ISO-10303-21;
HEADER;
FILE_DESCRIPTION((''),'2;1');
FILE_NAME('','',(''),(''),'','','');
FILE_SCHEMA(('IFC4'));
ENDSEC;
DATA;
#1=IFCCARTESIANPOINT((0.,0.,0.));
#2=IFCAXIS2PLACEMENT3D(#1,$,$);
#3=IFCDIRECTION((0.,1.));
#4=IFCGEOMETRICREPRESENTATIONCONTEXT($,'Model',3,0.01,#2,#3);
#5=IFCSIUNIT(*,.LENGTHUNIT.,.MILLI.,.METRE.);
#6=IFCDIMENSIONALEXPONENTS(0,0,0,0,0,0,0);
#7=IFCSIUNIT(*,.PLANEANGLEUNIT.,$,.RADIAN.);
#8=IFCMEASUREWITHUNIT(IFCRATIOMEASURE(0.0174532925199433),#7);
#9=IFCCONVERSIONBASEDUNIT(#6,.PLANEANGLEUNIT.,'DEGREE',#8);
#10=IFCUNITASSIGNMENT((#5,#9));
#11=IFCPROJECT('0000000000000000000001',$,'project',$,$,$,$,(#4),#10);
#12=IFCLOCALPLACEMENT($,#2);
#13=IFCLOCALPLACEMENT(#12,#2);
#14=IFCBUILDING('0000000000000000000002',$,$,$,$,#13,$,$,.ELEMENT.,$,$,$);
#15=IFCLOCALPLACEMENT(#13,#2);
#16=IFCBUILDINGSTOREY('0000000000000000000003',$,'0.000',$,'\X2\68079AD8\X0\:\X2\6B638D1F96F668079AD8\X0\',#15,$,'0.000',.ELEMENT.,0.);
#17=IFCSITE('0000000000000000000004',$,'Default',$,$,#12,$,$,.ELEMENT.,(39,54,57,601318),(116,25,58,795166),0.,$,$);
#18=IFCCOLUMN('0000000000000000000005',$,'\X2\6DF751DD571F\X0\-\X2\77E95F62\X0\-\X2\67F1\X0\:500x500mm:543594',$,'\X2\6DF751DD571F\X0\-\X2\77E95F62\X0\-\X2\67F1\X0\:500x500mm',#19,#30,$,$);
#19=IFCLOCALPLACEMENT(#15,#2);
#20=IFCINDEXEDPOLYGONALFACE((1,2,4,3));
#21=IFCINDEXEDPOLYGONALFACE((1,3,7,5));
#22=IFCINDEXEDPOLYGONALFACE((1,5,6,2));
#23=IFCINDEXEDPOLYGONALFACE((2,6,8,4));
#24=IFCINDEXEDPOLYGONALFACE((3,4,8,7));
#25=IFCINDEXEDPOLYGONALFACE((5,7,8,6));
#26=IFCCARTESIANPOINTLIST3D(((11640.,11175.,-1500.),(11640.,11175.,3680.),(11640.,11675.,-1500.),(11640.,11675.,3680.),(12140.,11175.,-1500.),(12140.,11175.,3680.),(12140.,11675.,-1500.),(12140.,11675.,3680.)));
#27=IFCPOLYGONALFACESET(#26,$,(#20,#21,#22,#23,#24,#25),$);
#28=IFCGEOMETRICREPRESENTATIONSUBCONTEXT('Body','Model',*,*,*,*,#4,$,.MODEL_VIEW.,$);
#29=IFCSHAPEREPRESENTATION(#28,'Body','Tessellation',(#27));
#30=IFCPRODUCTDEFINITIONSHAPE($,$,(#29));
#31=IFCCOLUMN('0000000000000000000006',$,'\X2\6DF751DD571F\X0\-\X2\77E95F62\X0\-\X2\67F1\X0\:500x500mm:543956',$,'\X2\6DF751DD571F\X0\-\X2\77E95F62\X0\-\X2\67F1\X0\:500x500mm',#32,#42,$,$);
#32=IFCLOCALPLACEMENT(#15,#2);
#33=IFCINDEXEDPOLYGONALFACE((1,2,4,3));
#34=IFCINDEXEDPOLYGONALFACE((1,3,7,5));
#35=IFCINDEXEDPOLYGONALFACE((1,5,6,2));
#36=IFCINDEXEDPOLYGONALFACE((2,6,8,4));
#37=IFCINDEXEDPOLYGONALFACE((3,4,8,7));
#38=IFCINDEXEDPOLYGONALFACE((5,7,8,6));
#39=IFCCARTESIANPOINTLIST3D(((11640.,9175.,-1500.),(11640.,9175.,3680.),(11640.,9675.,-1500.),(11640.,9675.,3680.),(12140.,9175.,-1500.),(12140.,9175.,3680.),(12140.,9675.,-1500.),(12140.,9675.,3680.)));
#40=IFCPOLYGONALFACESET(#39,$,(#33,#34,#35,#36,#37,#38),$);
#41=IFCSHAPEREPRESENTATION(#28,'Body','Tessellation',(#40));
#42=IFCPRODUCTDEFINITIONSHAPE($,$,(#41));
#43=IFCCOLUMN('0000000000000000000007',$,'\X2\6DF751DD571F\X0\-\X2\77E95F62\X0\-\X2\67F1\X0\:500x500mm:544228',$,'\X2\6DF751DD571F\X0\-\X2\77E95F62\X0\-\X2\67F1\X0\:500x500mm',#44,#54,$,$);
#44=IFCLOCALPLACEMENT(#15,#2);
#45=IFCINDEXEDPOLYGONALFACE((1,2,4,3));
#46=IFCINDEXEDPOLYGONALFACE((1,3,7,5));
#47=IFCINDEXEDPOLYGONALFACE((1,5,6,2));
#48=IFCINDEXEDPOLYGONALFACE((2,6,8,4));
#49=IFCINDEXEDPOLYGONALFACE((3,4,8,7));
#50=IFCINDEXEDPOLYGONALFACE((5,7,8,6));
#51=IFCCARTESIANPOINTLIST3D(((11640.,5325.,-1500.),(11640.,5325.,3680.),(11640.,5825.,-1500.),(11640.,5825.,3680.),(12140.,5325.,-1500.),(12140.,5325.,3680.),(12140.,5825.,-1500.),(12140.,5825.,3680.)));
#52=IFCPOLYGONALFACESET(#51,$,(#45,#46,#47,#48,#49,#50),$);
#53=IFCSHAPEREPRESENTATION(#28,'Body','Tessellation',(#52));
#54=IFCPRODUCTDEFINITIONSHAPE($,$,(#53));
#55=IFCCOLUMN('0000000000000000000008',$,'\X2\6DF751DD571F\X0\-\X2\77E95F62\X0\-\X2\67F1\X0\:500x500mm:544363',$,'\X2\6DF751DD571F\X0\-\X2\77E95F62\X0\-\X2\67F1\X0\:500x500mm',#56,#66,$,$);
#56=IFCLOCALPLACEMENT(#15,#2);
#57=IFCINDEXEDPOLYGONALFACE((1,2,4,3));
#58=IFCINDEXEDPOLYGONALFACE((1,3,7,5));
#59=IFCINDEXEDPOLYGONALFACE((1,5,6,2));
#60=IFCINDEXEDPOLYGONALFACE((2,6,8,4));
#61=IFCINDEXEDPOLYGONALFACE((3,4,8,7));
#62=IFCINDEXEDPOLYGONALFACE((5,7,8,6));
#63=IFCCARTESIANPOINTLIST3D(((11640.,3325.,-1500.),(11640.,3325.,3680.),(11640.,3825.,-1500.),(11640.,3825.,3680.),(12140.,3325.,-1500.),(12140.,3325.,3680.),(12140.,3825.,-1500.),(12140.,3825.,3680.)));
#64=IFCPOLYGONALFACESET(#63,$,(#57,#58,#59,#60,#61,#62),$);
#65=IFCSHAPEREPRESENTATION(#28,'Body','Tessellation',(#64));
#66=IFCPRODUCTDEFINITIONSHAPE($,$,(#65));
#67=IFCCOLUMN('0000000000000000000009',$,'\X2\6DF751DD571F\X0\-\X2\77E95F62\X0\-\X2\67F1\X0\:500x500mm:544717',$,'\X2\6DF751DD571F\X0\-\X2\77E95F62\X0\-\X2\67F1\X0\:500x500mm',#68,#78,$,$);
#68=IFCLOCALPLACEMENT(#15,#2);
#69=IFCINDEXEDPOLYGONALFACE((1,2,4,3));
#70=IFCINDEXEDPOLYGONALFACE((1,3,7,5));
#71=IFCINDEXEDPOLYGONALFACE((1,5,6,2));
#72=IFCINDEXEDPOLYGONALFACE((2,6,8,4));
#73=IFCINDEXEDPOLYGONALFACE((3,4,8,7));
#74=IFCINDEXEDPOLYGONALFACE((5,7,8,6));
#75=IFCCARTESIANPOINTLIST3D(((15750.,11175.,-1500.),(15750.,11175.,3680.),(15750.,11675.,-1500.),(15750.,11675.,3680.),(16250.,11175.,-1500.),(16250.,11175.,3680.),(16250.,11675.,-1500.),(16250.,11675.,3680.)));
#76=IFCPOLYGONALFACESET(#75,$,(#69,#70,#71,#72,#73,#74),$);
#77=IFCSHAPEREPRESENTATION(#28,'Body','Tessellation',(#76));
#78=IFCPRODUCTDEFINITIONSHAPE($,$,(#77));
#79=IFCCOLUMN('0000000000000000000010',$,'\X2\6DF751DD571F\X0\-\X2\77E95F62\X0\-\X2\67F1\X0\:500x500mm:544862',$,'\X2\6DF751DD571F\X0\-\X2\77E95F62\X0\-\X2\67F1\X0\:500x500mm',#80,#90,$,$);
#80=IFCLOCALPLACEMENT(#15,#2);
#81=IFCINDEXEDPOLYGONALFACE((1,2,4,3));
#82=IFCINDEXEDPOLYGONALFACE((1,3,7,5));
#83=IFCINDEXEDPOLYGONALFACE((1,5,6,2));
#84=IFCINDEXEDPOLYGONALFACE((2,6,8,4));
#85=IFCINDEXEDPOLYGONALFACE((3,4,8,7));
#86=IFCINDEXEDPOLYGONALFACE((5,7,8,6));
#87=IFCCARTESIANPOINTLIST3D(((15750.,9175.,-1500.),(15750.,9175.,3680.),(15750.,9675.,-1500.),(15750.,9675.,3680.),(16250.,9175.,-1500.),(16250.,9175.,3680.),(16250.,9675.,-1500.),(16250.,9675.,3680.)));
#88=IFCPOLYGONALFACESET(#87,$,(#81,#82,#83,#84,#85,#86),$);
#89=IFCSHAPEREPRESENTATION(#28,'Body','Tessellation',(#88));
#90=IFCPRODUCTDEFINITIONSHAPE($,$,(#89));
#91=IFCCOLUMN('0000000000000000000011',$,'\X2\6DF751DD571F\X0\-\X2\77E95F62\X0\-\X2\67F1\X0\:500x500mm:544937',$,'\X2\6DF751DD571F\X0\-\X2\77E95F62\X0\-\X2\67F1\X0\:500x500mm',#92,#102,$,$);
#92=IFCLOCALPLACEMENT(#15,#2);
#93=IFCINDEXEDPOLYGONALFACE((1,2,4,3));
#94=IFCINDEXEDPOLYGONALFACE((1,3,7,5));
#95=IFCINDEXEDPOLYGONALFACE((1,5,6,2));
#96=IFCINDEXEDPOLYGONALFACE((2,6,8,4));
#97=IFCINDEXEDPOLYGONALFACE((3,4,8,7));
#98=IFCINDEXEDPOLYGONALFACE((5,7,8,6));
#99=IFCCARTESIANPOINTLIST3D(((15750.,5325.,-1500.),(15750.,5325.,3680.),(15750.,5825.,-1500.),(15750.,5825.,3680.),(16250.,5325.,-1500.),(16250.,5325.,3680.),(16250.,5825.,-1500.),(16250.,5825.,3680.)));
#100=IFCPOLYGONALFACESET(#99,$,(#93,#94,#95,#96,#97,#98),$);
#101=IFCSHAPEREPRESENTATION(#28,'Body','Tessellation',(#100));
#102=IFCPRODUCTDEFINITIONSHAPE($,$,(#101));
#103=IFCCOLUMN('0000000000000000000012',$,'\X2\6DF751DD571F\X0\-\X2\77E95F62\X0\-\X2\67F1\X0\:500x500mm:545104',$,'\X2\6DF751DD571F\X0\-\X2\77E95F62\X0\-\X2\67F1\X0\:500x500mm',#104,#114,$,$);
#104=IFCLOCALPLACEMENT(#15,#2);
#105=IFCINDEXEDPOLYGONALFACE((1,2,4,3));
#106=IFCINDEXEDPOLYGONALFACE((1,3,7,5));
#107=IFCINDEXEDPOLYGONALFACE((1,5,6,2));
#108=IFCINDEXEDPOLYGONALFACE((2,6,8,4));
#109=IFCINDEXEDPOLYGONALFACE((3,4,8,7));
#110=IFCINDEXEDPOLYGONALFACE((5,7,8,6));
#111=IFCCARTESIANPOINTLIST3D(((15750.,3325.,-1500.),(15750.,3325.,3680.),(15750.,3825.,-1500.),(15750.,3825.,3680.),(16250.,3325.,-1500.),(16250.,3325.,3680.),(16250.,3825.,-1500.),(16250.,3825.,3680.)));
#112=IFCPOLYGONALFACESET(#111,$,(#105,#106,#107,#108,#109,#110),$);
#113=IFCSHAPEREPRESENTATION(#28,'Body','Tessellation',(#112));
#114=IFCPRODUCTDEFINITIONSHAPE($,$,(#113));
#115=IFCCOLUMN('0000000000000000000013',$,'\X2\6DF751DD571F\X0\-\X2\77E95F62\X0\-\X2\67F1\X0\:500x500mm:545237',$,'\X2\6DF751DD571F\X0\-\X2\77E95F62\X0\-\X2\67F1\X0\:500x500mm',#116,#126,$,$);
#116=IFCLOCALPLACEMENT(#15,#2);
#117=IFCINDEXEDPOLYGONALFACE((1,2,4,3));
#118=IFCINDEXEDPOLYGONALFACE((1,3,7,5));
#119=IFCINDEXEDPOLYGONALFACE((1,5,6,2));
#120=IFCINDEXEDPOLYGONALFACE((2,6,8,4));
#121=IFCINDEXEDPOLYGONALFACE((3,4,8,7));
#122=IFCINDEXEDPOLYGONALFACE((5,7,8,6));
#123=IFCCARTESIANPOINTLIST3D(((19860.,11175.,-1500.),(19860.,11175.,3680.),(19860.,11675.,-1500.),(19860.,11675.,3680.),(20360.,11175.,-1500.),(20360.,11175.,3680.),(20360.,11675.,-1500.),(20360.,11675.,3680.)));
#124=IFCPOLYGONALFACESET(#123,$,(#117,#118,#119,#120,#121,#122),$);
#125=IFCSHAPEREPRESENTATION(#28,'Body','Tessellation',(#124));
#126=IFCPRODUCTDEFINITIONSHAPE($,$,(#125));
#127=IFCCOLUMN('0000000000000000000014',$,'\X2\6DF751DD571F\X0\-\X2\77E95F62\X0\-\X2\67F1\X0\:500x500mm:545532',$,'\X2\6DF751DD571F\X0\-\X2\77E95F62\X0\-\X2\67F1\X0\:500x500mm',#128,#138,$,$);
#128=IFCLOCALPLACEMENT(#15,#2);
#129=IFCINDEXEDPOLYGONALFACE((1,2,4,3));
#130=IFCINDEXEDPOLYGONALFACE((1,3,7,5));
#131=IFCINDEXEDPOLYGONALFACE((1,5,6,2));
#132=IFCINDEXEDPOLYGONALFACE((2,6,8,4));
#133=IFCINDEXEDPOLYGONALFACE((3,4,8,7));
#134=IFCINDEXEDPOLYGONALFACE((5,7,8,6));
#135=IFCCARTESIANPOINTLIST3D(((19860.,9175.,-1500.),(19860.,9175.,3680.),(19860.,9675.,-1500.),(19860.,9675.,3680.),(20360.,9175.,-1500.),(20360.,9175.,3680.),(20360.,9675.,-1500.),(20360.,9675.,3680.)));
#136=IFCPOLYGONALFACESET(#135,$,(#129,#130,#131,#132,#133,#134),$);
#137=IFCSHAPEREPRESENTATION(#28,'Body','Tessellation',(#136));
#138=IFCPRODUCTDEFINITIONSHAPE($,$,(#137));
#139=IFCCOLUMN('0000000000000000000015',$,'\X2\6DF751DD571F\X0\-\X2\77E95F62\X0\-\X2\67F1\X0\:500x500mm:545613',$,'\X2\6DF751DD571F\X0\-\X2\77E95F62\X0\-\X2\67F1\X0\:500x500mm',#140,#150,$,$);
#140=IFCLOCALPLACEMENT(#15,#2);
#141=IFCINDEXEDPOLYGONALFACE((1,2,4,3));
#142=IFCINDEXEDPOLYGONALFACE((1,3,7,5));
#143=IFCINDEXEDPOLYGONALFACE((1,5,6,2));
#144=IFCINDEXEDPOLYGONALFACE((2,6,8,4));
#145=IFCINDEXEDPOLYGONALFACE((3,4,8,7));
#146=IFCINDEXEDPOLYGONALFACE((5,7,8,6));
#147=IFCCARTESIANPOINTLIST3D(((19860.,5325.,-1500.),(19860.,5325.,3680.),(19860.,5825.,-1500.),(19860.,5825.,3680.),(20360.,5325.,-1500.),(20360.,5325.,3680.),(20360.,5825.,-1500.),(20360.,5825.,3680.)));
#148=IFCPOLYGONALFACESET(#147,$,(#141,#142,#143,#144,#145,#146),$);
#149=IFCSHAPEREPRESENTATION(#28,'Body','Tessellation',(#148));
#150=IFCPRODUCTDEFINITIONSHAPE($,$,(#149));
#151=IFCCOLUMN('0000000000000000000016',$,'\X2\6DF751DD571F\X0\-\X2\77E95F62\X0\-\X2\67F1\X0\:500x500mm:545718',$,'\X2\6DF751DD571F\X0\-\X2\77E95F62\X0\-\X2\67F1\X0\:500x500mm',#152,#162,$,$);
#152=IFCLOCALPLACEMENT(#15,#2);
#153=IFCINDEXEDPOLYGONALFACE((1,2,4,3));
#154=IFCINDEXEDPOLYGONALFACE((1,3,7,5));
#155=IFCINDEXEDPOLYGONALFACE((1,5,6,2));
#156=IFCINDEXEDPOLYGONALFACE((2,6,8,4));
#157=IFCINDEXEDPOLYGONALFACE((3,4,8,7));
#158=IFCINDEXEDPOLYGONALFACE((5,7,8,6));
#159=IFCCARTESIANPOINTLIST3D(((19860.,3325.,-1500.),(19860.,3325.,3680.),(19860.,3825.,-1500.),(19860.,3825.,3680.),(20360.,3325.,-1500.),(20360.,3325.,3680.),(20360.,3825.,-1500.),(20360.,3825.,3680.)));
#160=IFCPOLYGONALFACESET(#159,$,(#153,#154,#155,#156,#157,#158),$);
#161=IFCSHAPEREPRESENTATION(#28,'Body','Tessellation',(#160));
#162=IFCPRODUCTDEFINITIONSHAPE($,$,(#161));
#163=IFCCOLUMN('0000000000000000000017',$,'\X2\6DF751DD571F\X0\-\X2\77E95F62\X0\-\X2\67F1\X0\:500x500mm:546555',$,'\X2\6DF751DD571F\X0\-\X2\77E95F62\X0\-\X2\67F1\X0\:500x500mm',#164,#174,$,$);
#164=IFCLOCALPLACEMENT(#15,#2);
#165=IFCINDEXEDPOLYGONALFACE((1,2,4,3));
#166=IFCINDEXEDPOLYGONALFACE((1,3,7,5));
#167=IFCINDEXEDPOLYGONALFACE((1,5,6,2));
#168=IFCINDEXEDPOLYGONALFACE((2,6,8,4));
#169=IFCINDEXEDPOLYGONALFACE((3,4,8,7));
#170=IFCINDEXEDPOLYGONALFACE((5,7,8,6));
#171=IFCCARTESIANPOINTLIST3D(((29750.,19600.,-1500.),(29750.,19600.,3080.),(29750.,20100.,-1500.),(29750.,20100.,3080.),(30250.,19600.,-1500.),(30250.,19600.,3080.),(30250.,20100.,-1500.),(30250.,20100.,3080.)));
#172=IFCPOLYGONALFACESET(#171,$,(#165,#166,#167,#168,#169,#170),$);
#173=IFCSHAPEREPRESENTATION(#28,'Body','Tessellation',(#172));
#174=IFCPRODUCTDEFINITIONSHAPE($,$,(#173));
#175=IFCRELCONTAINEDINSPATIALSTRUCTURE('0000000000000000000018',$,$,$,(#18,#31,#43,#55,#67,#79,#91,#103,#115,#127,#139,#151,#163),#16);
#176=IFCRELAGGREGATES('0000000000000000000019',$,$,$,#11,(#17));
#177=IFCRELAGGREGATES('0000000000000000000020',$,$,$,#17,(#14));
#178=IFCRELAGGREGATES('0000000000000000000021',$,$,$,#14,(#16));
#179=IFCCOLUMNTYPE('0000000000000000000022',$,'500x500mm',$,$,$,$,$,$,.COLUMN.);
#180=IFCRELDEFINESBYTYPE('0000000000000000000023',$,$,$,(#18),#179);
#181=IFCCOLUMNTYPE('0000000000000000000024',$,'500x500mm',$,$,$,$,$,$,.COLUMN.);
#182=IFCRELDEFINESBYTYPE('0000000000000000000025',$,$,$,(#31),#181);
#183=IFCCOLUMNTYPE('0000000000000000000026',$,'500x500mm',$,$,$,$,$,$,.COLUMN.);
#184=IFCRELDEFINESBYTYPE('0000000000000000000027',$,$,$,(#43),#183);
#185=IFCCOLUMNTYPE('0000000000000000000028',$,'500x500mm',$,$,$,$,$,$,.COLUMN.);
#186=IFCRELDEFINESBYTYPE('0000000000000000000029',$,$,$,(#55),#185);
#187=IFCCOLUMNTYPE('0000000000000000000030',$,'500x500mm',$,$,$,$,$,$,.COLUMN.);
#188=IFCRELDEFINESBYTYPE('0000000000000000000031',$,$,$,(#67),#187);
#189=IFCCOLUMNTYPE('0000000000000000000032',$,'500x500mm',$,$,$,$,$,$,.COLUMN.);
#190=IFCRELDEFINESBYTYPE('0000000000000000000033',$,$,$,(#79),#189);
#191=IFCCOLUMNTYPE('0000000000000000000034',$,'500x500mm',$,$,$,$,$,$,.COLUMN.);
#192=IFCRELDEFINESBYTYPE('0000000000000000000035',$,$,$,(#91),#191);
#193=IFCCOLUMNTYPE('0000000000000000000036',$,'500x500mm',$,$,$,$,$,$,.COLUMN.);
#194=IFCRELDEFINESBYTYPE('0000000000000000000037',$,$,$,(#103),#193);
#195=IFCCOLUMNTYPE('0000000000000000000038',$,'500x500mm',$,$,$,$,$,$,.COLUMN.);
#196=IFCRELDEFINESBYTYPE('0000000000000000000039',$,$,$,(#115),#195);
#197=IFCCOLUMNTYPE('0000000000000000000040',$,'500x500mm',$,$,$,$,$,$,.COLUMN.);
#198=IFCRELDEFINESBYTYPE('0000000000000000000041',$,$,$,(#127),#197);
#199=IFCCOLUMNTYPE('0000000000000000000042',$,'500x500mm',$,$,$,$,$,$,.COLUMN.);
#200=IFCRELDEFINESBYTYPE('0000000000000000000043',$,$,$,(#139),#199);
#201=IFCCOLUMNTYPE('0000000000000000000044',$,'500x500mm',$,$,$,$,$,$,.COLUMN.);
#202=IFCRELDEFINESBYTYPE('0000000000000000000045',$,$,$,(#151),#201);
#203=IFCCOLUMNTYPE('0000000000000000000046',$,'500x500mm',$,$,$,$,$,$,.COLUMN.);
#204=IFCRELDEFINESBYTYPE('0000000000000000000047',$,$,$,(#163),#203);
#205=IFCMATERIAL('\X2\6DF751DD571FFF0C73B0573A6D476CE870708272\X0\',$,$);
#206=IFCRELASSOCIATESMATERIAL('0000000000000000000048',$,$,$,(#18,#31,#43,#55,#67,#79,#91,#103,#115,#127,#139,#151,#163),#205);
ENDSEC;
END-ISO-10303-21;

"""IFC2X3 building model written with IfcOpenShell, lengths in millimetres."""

from ifc_helpers import new_model, entity, si_unit, converted_unit, direction, frame, frame_2d, origin, origin_2d_with_axis, place, context, subcontext, project, spatial, rectangle, extrude, source, transform, mapped, material, type_object, type_shapes, element, save


model = new_model("IFC2X3")

# Units and contexts
model_context = context("Model", 3, precision=0.01, world=origin(), true_north=direction((0.0, 1.0)))
body_context = subcontext(model_context, "Body", "Model", "MODEL_VIEW")
ifc_project = project(units=[si_unit("LENGTHUNIT", "METRE", prefix="MILLI"), converted_unit("PLANEANGLEUNIT", "DEGREE", entity("IfcRatioMeasure", 0.0174532925199433), si_unit("PLANEANGLEUNIT", "RADIAN"), dimensions=[0, 0, 0, 0, 0, 0, 0])], contexts=[model_context])

# Site, building, storey
site_placement = place(None, origin())
site = spatial("IfcSite", under=ifc_project, at=site_placement, Name="Default", CompositionType="ELEMENT", RefLatitude=(39, 54, 57, 601318), RefLongitude=(116, 25, 58, 795166), RefElevation=0.0)
building_placement = place(site_placement, origin())
building = spatial("IfcBuilding", under=site, at=building_placement, CompositionType="ELEMENT")
storey_placement = place(building_placement, origin())
storey = spatial("IfcBuildingStorey", under=building, at=storey_placement, Name="0.000", ObjectType="标高:正负零标高", LongName="0.000", CompositionType="ELEMENT", Elevation=0.0)

# Columns
ifc_material = material(Name="混凝土，现场浇注灰色")
column_type_1 = type_object("IfcColumnType", Name="500x500mm", PredefinedType="COLUMN")
shared_shape_1 = source(origin(), body_context, "Body", "SweptSolid", [
    extrude(rectangle(XDim=500.0, YDim=500.0, at=origin_2d_with_axis()), frame((11890.0, 11425.0, -1500.0), z_axis=(0.0, 0.0, 1.0), x_axis=(0.0, -1.0, 0.0)), (0.0, 0.0, 1.0), 5180.0),
])
type_shapes(column_type_1, [shared_shape_1])
column_1_placement = place(storey_placement, origin())
element("IfcColumn", 1, at=column_1_placement, inside=storey, type_object=column_type_1, material=ifc_material, Name="混凝土-矩形-柱:500x500mm:543594", ObjectType="混凝土-矩形-柱:500x500mm", context=body_context, shape_type="MappedRepresentation", body=[
    mapped(shared_shape_1, transform((0.0, 0.0, 0.0), scale=1.0)),
])
column_type_2 = type_object("IfcColumnType", Name="500x500mm", PredefinedType="COLUMN")
shared_shape_2 = source(origin(), body_context, "Body", "SweptSolid", [
    extrude(rectangle(XDim=500.0, YDim=500.0, at=frame_2d((0.0, 0.0), x_axis=(1.0, 0.0))), frame((11890.0, 9425.0, -1500.0), z_axis=(0.0, 0.0, 1.0), x_axis=(0.0, -1.0, 0.0)), (0.0, 0.0, 1.0), 5180.0),
])
type_shapes(column_type_2, [shared_shape_2])
column_2_placement = place(storey_placement, origin())
element("IfcColumn", 2, at=column_2_placement, inside=storey, type_object=column_type_2, material=ifc_material, Name="混凝土-矩形-柱:500x500mm:543956", ObjectType="混凝土-矩形-柱:500x500mm", context=body_context, shape_type="MappedRepresentation", body=[
    mapped(shared_shape_2, transform((0.0, 0.0, 0.0), scale=1.0)),
])
column_type_3 = type_object("IfcColumnType", Name="500x500mm", PredefinedType="COLUMN")
shared_shape_3 = source(origin(), body_context, "Body", "SweptSolid", [
    extrude(rectangle(XDim=500.0, YDim=500.0, at=origin_2d_with_axis()), frame((11890.0, 5575.0, -1500.0), z_axis=(0.0, 0.0, 1.0), x_axis=(0.0, -1.0, 0.0)), (0.0, 0.0, 1.0), 5180.0),
])
type_shapes(column_type_3, [shared_shape_3])
column_3_placement = place(storey_placement, origin())
element("IfcColumn", 3, at=column_3_placement, inside=storey, type_object=column_type_3, material=ifc_material, Name="混凝土-矩形-柱:500x500mm:544228", ObjectType="混凝土-矩形-柱:500x500mm", context=body_context, shape_type="MappedRepresentation", body=[
    mapped(shared_shape_3, transform((0.0, 0.0, 0.0), scale=1.0)),
])
column_type_4 = type_object("IfcColumnType", Name="500x500mm", PredefinedType="COLUMN")
shared_shape_4 = source(origin(), body_context, "Body", "SweptSolid", [
    extrude(rectangle(XDim=500.0, YDim=500.0, at=origin_2d_with_axis()), frame((11890.0, 3575.0, -1500.0), z_axis=(0.0, 0.0, 1.0), x_axis=(0.0, -1.0, 0.0)), (0.0, 0.0, 1.0), 5180.0),
])
type_shapes(column_type_4, [shared_shape_4])
column_4_placement = place(storey_placement, origin())
element("IfcColumn", 4, at=column_4_placement, inside=storey, type_object=column_type_4, material=ifc_material, Name="混凝土-矩形-柱:500x500mm:544363", ObjectType="混凝土-矩形-柱:500x500mm", context=body_context, shape_type="MappedRepresentation", body=[
    mapped(shared_shape_4, transform((0.0, 0.0, 0.0), scale=1.0)),
])
column_type_5 = type_object("IfcColumnType", Name="500x500mm", PredefinedType="COLUMN")
shared_shape_5 = source(origin(), body_context, "Body", "SweptSolid", [
    extrude(rectangle(XDim=500.0, YDim=500.0, at=origin_2d_with_axis()), frame((16000.0, 11425.0, -1500.0), z_axis=(0.0, 0.0, 1.0), x_axis=(0.0, -1.0, 0.0)), (0.0, 0.0, 1.0), 5180.0),
])
type_shapes(column_type_5, [shared_shape_5])
column_5_placement = place(storey_placement, origin())
element("IfcColumn", 5, at=column_5_placement, inside=storey, type_object=column_type_5, material=ifc_material, Name="混凝土-矩形-柱:500x500mm:544717", ObjectType="混凝土-矩形-柱:500x500mm", context=body_context, shape_type="MappedRepresentation", body=[
    mapped(shared_shape_5, transform((0.0, 0.0, 0.0), scale=1.0)),
])
column_type_6 = type_object("IfcColumnType", Name="500x500mm", PredefinedType="COLUMN")
shared_shape_6 = source(origin(), body_context, "Body", "SweptSolid", [
    extrude(rectangle(XDim=500.0, YDim=500.0, at=frame_2d((0.0, 0.0), x_axis=(1.0, 0.0))), frame((16000.0, 9425.0, -1500.0), z_axis=(0.0, 0.0, 1.0), x_axis=(0.0, -1.0, 0.0)), (0.0, 0.0, 1.0), 5180.0),
])
type_shapes(column_type_6, [shared_shape_6])
column_6_placement = place(storey_placement, origin())
element("IfcColumn", 6, at=column_6_placement, inside=storey, type_object=column_type_6, material=ifc_material, Name="混凝土-矩形-柱:500x500mm:544862", ObjectType="混凝土-矩形-柱:500x500mm", context=body_context, shape_type="MappedRepresentation", body=[
    mapped(shared_shape_6, transform((0.0, 0.0, 0.0), scale=1.0)),
])
column_type_7 = type_object("IfcColumnType", Name="500x500mm", PredefinedType="COLUMN")
shared_shape_7 = source(origin(), body_context, "Body", "SweptSolid", [
    extrude(rectangle(XDim=500.0, YDim=500.0, at=origin_2d_with_axis()), frame((16000.0, 5575.0, -1500.0), z_axis=(0.0, 0.0, 1.0), x_axis=(0.0, -1.0, 0.0)), (0.0, 0.0, 1.0), 5180.0),
])
type_shapes(column_type_7, [shared_shape_7])
column_7_placement = place(storey_placement, origin())
element("IfcColumn", 7, at=column_7_placement, inside=storey, type_object=column_type_7, material=ifc_material, Name="混凝土-矩形-柱:500x500mm:544937", ObjectType="混凝土-矩形-柱:500x500mm", context=body_context, shape_type="MappedRepresentation", body=[
    mapped(shared_shape_7, transform((0.0, 0.0, 0.0), scale=1.0)),
])
column_type_8 = type_object("IfcColumnType", Name="500x500mm", PredefinedType="COLUMN")
shared_shape_8 = source(origin(), body_context, "Body", "SweptSolid", [
    extrude(rectangle(XDim=500.0, YDim=500.0, at=origin_2d_with_axis()), frame((16000.0, 3575.0, -1500.0), z_axis=(0.0, 0.0, 1.0), x_axis=(0.0, -1.0, 0.0)), (0.0, 0.0, 1.0), 5180.0),
])
type_shapes(column_type_8, [shared_shape_8])
column_8_placement = place(storey_placement, origin())
element("IfcColumn", 8, at=column_8_placement, inside=storey, type_object=column_type_8, material=ifc_material, Name="混凝土-矩形-柱:500x500mm:545104", ObjectType="混凝土-矩形-柱:500x500mm", context=body_context, shape_type="MappedRepresentation", body=[
    mapped(shared_shape_8, transform((0.0, 0.0, 0.0), scale=1.0)),
])
column_type_9 = type_object("IfcColumnType", Name="500x500mm", PredefinedType="COLUMN")
shared_shape_9 = source(origin(), body_context, "Body", "SweptSolid", [
    extrude(rectangle(XDim=500.0, YDim=500.0, at=origin_2d_with_axis()), frame((20110.0, 11425.0, -1500.0), z_axis=(0.0, 0.0, 1.0), x_axis=(0.0, -1.0, 0.0)), (0.0, 0.0, 1.0), 5180.0),
])
type_shapes(column_type_9, [shared_shape_9])
column_9_placement = place(storey_placement, origin())
element("IfcColumn", 9, at=column_9_placement, inside=storey, type_object=column_type_9, material=ifc_material, Name="混凝土-矩形-柱:500x500mm:545237", ObjectType="混凝土-矩形-柱:500x500mm", context=body_context, shape_type="MappedRepresentation", body=[
    mapped(shared_shape_9, transform((0.0, 0.0, 0.0), scale=1.0)),
])
column_type_10 = type_object("IfcColumnType", Name="500x500mm", PredefinedType="COLUMN")
shared_shape_10 = source(origin(), body_context, "Body", "SweptSolid", [
    extrude(rectangle(XDim=500.0, YDim=500.0, at=frame_2d((0.0, 0.0), x_axis=(1.0, 0.0))), frame((20110.0, 9425.0, -1500.0), z_axis=(0.0, 0.0, 1.0), x_axis=(0.0, -1.0, 0.0)), (0.0, 0.0, 1.0), 5180.0),
])
type_shapes(column_type_10, [shared_shape_10])
column_10_placement = place(storey_placement, origin())
element("IfcColumn", 10, at=column_10_placement, inside=storey, type_object=column_type_10, material=ifc_material, Name="混凝土-矩形-柱:500x500mm:545532", ObjectType="混凝土-矩形-柱:500x500mm", context=body_context, shape_type="MappedRepresentation", body=[
    mapped(shared_shape_10, transform((0.0, 0.0, 0.0), scale=1.0)),
])
column_type_11 = type_object("IfcColumnType", Name="500x500mm", PredefinedType="COLUMN")
shared_shape_11 = source(origin(), body_context, "Body", "SweptSolid", [
    extrude(rectangle(XDim=500.0, YDim=500.0, at=origin_2d_with_axis()), frame((20110.0, 5575.0, -1500.0), z_axis=(0.0, 0.0, 1.0), x_axis=(0.0, -1.0, 0.0)), (0.0, 0.0, 1.0), 5180.0),
])
type_shapes(column_type_11, [shared_shape_11])
column_11_placement = place(storey_placement, origin())
element("IfcColumn", 11, at=column_11_placement, inside=storey, type_object=column_type_11, material=ifc_material, Name="混凝土-矩形-柱:500x500mm:545613", ObjectType="混凝土-矩形-柱:500x500mm", context=body_context, shape_type="MappedRepresentation", body=[
    mapped(shared_shape_11, transform((0.0, 0.0, 0.0), scale=1.0)),
])
column_type_12 = type_object("IfcColumnType", Name="500x500mm", PredefinedType="COLUMN")
shared_shape_12 = source(origin(), body_context, "Body", "SweptSolid", [
    extrude(rectangle(XDim=500.0, YDim=500.0, at=origin_2d_with_axis()), frame((20110.0, 3575.0, -1500.0), z_axis=(0.0, 0.0, 1.0), x_axis=(0.0, -1.0, 0.0)), (0.0, 0.0, 1.0), 5180.0),
])
type_shapes(column_type_12, [shared_shape_12])
column_12_placement = place(storey_placement, origin())
element("IfcColumn", 12, at=column_12_placement, inside=storey, type_object=column_type_12, material=ifc_material, Name="混凝土-矩形-柱:500x500mm:545718", ObjectType="混凝土-矩形-柱:500x500mm", context=body_context, shape_type="MappedRepresentation", body=[
    mapped(shared_shape_12, transform((0.0, 0.0, 0.0), scale=1.0)),
])
column_type_13 = type_object("IfcColumnType", Name="500x500mm", PredefinedType="COLUMN")
shared_shape_13 = source(origin(), body_context, "Body", "SweptSolid", [
    extrude(rectangle(XDim=500.0, YDim=500.0, at=origin_2d_with_axis()), frame((30000.0, 19850.0, -1500.0), z_axis=(0.0, 0.0, 1.0), x_axis=(0.0, -1.0, 0.0)), (0.0, 0.0, 1.0), 4580.0),
])
type_shapes(column_type_13, [shared_shape_13])
column_13_placement = place(storey_placement, origin())
element("IfcColumn", 13, at=column_13_placement, inside=storey, type_object=column_type_13, material=ifc_material, Name="混凝土-矩形-柱:500x500mm:546555", ObjectType="混凝土-矩形-柱:500x500mm", context=body_context, shape_type="MappedRepresentation", body=[
    mapped(shared_shape_13, transform((0.0, 0.0, 0.0), scale=1.0)),
])

save(model, "model.ifc")
